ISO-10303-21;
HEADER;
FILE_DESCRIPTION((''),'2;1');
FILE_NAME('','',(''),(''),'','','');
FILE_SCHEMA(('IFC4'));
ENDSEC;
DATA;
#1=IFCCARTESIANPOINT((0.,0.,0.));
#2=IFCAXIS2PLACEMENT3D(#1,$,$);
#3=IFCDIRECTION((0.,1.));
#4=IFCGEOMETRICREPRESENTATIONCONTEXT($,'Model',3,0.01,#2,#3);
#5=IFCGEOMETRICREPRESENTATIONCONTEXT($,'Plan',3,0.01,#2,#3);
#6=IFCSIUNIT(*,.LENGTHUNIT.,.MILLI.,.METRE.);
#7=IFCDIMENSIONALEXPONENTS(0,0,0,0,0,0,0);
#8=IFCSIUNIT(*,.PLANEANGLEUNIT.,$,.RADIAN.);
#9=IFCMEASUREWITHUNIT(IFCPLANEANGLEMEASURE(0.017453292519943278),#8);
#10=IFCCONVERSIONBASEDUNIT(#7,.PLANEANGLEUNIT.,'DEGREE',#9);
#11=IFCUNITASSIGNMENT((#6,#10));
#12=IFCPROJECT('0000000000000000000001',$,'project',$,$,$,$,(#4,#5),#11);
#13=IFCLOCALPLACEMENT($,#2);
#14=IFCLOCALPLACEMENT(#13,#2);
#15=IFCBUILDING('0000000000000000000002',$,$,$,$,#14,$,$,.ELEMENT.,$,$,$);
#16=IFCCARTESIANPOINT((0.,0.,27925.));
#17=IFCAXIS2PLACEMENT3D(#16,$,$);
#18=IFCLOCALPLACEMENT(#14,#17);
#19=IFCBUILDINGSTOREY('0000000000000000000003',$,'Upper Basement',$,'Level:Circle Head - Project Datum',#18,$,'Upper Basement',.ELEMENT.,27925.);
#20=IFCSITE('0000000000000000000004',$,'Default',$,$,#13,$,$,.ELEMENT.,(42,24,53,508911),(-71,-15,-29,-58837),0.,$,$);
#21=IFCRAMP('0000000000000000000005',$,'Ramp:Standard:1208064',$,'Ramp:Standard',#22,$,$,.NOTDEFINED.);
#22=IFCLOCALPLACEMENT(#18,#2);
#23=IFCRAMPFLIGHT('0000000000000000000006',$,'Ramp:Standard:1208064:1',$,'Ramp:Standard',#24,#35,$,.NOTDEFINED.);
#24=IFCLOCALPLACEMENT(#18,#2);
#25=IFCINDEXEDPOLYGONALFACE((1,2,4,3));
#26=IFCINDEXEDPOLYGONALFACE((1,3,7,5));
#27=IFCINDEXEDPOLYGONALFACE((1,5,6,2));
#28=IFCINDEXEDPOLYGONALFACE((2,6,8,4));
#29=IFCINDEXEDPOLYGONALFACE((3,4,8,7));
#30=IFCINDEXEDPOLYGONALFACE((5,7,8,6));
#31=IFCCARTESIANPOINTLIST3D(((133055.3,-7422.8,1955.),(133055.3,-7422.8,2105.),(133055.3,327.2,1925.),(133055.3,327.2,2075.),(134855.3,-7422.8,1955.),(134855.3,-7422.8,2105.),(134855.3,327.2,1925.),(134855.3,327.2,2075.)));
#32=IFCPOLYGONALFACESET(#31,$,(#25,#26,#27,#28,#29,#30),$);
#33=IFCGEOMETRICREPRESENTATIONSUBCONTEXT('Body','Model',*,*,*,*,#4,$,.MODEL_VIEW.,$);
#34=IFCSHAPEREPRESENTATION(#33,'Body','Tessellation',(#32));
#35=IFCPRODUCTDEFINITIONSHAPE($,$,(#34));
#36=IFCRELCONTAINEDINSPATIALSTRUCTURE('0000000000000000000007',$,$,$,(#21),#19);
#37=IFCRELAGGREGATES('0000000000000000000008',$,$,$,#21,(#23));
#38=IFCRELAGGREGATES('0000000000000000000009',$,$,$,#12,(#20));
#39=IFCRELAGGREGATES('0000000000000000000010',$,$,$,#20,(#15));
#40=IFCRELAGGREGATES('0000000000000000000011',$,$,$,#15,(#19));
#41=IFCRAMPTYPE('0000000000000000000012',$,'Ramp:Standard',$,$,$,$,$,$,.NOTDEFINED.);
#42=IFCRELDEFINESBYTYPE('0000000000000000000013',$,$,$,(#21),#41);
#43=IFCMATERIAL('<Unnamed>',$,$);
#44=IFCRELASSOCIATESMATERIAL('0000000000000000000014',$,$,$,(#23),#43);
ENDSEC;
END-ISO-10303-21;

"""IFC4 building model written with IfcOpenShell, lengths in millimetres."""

from ifc_helpers import new_model, entity, si_unit, converted_unit, direction, frame, origin, place, context, subcontext, project, spatial, indexed_curve, outline, extrude, material, type_object, element, aggregate, save


model = new_model("IFC4")

# Units and contexts
model_context = context("Model", 3, precision=0.01, world=origin(), true_north=direction((0.0, 1.0)))
plan_context = context("Plan", 3, precision=0.01, world=origin(), true_north=direction((0.0, 1.0)))
body_context = subcontext(model_context, "Body", "Model", "MODEL_VIEW")
ifc_project = project(units=[si_unit("LENGTHUNIT", "METRE", prefix="MILLI"), converted_unit("PLANEANGLEUNIT", "DEGREE", entity("IfcPlaneAngleMeasure", 0.017453292519943278), si_unit("PLANEANGLEUNIT", "RADIAN"), dimensions=[0, 0, 0, 0, 0, 0, 0])], contexts=[model_context, plan_context])

# Site, building, storey
site_placement = place(None, origin())
site = spatial("IfcSite", under=ifc_project, at=site_placement, Name="Default", CompositionType="ELEMENT", RefLatitude=(42, 24, 53, 508911), RefLongitude=(-71, -15, -29, -58837), RefElevation=0.0)
building_placement = place(site_placement, origin())
building = spatial("IfcBuilding", under=site, at=building_placement, CompositionType="ELEMENT")
storey_placement = place(building_placement, frame((0.0, 0.0, 27925.0)))
storey = spatial("IfcBuildingStorey", under=building, at=storey_placement, Name="Upper Basement", ObjectType="Level:Circle Head - Project Datum", LongName="Upper Basement", CompositionType="ELEMENT", Elevation=27925.0)

# Ramp, ramp flight
ramp_type = type_object("IfcRampType", Name="Ramp:Standard", PredefinedType="NOTDEFINED")
ifc_material_1 = material(Name="<Unnamed>")
ramp_1_placement = place(storey_placement, origin())
ramp_1 = element("IfcRamp", 1, at=ramp_1_placement, inside=storey, type_object=ramp_type, Name="Ramp:Standard:1208064", ObjectType="Ramp:Standard", PredefinedType="NOTDEFINED")
ramp_flight_1_placement = place(ramp_1_placement, origin())
ramp_flight_1 = element("IfcRampFlight", 2, at=ramp_flight_1_placement, material=ifc_material_1, Name="Ramp:Standard:1208064:1", ObjectType="Ramp:Standard", PredefinedType="NOTDEFINED", context=body_context, shape_type="SweptSolid", body=[
    extrude(outline(indexed_curve([(-3875.0, -900.0), (3875.0, -900.0), (3875.0, 900.0), (-3875.0, 900.0), (-3875.0, -900.0)], self_intersect=False)), frame((133955.3, -3547.8, 1940.0), z_axis=(0.0, 0.003871, 0.999993), x_axis=(0.0, 0.999993, -0.003871)), (-0.003871, 0.0, 0.999993), 150.0),
])
aggregate(ramp_1, [ramp_flight_1])

save(model, "model.ifc")
